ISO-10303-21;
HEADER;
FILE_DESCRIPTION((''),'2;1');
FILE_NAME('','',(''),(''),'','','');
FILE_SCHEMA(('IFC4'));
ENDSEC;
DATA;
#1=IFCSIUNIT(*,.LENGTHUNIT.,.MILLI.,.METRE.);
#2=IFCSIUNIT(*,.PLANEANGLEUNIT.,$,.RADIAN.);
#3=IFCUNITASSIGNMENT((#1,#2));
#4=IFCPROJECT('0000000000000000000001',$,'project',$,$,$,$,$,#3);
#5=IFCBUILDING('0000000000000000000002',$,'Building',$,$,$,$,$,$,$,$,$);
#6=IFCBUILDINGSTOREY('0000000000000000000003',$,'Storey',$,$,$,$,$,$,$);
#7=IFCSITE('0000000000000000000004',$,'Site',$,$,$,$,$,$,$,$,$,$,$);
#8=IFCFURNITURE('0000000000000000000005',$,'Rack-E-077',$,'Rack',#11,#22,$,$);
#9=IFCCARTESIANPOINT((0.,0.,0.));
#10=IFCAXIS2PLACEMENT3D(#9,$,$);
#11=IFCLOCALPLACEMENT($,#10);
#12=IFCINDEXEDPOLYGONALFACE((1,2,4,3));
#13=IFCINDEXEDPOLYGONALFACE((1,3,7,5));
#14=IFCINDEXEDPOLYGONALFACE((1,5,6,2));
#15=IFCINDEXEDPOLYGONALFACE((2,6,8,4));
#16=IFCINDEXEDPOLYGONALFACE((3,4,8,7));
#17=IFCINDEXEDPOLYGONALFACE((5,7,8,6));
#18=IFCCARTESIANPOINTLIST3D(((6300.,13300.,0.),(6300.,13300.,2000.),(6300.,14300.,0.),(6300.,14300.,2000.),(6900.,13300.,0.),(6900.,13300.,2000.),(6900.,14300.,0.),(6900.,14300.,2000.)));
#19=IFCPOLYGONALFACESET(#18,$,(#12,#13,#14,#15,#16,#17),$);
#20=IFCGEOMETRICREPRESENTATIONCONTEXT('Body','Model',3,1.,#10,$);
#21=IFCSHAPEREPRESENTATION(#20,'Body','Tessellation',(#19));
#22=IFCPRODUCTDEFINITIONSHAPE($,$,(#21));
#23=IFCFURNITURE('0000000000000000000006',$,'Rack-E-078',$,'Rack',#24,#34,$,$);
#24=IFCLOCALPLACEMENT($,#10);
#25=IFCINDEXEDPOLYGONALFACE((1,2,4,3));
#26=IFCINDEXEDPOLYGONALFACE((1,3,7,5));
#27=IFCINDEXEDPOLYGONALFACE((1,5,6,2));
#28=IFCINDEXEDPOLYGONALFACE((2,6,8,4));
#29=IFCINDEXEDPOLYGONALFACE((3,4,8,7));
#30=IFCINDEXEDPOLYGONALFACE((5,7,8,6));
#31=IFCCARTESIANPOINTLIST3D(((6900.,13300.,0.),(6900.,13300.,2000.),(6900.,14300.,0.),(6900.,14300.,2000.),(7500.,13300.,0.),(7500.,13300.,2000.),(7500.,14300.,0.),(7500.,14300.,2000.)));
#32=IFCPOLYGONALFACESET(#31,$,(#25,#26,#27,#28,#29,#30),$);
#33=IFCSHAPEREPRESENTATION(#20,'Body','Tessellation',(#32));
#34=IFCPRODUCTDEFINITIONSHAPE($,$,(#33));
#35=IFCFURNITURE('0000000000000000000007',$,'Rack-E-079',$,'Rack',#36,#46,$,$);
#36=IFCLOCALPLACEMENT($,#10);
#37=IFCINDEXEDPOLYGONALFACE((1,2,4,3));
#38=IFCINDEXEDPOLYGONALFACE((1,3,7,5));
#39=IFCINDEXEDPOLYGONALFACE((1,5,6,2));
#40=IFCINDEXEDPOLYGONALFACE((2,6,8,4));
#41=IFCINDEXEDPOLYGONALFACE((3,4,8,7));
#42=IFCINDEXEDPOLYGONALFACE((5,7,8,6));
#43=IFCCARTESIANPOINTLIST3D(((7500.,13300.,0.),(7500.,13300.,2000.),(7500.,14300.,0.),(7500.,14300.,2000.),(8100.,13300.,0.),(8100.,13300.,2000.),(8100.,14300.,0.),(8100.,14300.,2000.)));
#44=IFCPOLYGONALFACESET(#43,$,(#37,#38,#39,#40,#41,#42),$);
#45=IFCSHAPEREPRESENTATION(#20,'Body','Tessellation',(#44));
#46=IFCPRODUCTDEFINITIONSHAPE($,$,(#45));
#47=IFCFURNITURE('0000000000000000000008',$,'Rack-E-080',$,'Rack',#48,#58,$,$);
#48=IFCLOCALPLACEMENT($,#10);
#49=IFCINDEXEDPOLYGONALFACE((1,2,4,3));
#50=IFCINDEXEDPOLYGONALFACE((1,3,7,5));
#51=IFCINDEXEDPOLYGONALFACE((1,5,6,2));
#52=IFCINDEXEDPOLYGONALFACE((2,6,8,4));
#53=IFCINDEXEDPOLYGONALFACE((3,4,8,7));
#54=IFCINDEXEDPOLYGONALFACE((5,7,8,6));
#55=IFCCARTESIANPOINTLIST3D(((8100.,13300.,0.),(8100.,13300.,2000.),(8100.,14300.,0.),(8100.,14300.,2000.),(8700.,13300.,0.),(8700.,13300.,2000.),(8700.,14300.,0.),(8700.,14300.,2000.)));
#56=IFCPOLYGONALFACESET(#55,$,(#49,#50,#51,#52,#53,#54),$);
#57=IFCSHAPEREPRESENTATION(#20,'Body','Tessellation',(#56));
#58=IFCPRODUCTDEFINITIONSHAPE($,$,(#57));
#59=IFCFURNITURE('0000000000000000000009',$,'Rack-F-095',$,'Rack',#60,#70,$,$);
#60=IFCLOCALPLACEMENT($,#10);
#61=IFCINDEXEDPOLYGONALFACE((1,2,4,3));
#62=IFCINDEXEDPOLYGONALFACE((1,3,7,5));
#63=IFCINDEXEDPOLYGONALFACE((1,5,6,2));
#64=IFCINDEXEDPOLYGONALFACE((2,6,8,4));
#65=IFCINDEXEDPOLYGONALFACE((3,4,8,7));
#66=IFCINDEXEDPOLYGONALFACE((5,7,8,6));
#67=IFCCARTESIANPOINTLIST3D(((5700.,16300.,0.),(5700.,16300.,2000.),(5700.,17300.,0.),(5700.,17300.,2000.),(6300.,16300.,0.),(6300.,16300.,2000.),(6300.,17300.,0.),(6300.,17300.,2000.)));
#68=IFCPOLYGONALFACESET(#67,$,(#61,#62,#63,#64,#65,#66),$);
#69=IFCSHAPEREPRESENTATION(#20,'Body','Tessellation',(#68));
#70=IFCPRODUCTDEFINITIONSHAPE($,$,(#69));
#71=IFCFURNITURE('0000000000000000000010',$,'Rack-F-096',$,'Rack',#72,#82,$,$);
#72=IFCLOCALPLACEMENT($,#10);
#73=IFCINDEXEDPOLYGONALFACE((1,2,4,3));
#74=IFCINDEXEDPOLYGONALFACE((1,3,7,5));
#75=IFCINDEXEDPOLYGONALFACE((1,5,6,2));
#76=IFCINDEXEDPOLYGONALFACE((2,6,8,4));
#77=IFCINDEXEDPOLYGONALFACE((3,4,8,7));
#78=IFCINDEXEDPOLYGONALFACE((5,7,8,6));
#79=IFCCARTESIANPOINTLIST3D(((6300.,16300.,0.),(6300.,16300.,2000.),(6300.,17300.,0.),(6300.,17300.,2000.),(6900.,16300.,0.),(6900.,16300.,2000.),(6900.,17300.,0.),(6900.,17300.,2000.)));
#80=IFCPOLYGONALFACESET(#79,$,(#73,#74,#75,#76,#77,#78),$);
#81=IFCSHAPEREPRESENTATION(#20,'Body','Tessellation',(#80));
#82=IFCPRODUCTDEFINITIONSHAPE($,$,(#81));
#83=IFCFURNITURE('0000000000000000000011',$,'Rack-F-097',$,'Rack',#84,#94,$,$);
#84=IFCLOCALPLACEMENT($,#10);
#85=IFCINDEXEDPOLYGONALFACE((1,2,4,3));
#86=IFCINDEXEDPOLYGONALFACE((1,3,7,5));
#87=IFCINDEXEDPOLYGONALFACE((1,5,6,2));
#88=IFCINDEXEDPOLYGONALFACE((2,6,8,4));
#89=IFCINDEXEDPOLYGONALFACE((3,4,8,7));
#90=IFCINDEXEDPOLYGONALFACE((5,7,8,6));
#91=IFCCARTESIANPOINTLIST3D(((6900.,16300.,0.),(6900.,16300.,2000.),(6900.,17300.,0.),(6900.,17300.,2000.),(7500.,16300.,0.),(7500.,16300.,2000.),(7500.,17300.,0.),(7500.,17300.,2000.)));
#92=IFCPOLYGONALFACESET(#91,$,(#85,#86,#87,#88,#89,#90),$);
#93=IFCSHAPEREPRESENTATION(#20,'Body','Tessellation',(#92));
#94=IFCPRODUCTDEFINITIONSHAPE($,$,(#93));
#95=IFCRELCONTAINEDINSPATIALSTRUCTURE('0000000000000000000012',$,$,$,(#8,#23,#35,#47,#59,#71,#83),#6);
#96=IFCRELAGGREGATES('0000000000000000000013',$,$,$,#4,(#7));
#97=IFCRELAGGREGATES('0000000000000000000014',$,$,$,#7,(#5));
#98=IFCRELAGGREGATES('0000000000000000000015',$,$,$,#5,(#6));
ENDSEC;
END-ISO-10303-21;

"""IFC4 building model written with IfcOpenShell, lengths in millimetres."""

from ifc_helpers import new_model, si_unit, frame, origin, place, context, project, spatial, rectangle, extrude, element, save


model = new_model("IFC4")

# Units and contexts
model_context = context("Model", 3, precision=1.0, world=origin(), identifier="Body")
ifc_project = project(units=[si_unit("LENGTHUNIT", "METRE", prefix="MILLI"), si_unit("PLANEANGLEUNIT", "RADIAN")])

# Site, building, storey
site = spatial("IfcSite", under=ifc_project, Name="Site")
building = spatial("IfcBuilding", under=site, Name="Building")
storey = spatial("IfcBuildingStorey", under=building, Name="Storey")

# Furniture
for number, where, z_axis, x_axis, name in (
    (1, (6600.0, 13800.0, 0.0), (0.0, 0.0, 1.0), (1.0, 0.0, 0.0), "Rack-E-077"),
    (2, (7200.0, 13800.0, 0.0), (0.0, 0.0, 1.0), (1.0, 0.0, 0.0), "Rack-E-078"),
    (3, (7800.0, 13800.0, 0.0), (0.0, 0.0, 1.0), (1.0, 0.0, 0.0), "Rack-E-079"),
    (4, (8400.0, 13800.0, 0.0), (0.0, 0.0, 1.0), (1.0, 0.0, 0.0), "Rack-E-080"),
    (5, (6000.0, 16800.0, 0.0), (0.0, 0.0, 1.0), (1.0, 0.0, 0.0), "Rack-F-095"),
    (6, (6600.0, 16800.0, 0.0), (0.0, 0.0, 1.0), (1.0, 0.0, 0.0), "Rack-F-096"),
    (7, (7200.0, 16800.0, 0.0), (0.0, 0.0, 1.0), (1.0, 0.0, 0.0), "Rack-F-097"),
):
    element("IfcFurniture", number, at=place(None, frame(where, z_axis=z_axis, x_axis=x_axis)), inside=storey, Name=name, ObjectType="Rack", context=model_context, shape_type="SweptSolid", body=[
        extrude(rectangle(XDim=600.0, YDim=1000.0), origin(), (0.0, 0.0, 1.0), 2000.0),
    ])

save(model, "model.ifc")
